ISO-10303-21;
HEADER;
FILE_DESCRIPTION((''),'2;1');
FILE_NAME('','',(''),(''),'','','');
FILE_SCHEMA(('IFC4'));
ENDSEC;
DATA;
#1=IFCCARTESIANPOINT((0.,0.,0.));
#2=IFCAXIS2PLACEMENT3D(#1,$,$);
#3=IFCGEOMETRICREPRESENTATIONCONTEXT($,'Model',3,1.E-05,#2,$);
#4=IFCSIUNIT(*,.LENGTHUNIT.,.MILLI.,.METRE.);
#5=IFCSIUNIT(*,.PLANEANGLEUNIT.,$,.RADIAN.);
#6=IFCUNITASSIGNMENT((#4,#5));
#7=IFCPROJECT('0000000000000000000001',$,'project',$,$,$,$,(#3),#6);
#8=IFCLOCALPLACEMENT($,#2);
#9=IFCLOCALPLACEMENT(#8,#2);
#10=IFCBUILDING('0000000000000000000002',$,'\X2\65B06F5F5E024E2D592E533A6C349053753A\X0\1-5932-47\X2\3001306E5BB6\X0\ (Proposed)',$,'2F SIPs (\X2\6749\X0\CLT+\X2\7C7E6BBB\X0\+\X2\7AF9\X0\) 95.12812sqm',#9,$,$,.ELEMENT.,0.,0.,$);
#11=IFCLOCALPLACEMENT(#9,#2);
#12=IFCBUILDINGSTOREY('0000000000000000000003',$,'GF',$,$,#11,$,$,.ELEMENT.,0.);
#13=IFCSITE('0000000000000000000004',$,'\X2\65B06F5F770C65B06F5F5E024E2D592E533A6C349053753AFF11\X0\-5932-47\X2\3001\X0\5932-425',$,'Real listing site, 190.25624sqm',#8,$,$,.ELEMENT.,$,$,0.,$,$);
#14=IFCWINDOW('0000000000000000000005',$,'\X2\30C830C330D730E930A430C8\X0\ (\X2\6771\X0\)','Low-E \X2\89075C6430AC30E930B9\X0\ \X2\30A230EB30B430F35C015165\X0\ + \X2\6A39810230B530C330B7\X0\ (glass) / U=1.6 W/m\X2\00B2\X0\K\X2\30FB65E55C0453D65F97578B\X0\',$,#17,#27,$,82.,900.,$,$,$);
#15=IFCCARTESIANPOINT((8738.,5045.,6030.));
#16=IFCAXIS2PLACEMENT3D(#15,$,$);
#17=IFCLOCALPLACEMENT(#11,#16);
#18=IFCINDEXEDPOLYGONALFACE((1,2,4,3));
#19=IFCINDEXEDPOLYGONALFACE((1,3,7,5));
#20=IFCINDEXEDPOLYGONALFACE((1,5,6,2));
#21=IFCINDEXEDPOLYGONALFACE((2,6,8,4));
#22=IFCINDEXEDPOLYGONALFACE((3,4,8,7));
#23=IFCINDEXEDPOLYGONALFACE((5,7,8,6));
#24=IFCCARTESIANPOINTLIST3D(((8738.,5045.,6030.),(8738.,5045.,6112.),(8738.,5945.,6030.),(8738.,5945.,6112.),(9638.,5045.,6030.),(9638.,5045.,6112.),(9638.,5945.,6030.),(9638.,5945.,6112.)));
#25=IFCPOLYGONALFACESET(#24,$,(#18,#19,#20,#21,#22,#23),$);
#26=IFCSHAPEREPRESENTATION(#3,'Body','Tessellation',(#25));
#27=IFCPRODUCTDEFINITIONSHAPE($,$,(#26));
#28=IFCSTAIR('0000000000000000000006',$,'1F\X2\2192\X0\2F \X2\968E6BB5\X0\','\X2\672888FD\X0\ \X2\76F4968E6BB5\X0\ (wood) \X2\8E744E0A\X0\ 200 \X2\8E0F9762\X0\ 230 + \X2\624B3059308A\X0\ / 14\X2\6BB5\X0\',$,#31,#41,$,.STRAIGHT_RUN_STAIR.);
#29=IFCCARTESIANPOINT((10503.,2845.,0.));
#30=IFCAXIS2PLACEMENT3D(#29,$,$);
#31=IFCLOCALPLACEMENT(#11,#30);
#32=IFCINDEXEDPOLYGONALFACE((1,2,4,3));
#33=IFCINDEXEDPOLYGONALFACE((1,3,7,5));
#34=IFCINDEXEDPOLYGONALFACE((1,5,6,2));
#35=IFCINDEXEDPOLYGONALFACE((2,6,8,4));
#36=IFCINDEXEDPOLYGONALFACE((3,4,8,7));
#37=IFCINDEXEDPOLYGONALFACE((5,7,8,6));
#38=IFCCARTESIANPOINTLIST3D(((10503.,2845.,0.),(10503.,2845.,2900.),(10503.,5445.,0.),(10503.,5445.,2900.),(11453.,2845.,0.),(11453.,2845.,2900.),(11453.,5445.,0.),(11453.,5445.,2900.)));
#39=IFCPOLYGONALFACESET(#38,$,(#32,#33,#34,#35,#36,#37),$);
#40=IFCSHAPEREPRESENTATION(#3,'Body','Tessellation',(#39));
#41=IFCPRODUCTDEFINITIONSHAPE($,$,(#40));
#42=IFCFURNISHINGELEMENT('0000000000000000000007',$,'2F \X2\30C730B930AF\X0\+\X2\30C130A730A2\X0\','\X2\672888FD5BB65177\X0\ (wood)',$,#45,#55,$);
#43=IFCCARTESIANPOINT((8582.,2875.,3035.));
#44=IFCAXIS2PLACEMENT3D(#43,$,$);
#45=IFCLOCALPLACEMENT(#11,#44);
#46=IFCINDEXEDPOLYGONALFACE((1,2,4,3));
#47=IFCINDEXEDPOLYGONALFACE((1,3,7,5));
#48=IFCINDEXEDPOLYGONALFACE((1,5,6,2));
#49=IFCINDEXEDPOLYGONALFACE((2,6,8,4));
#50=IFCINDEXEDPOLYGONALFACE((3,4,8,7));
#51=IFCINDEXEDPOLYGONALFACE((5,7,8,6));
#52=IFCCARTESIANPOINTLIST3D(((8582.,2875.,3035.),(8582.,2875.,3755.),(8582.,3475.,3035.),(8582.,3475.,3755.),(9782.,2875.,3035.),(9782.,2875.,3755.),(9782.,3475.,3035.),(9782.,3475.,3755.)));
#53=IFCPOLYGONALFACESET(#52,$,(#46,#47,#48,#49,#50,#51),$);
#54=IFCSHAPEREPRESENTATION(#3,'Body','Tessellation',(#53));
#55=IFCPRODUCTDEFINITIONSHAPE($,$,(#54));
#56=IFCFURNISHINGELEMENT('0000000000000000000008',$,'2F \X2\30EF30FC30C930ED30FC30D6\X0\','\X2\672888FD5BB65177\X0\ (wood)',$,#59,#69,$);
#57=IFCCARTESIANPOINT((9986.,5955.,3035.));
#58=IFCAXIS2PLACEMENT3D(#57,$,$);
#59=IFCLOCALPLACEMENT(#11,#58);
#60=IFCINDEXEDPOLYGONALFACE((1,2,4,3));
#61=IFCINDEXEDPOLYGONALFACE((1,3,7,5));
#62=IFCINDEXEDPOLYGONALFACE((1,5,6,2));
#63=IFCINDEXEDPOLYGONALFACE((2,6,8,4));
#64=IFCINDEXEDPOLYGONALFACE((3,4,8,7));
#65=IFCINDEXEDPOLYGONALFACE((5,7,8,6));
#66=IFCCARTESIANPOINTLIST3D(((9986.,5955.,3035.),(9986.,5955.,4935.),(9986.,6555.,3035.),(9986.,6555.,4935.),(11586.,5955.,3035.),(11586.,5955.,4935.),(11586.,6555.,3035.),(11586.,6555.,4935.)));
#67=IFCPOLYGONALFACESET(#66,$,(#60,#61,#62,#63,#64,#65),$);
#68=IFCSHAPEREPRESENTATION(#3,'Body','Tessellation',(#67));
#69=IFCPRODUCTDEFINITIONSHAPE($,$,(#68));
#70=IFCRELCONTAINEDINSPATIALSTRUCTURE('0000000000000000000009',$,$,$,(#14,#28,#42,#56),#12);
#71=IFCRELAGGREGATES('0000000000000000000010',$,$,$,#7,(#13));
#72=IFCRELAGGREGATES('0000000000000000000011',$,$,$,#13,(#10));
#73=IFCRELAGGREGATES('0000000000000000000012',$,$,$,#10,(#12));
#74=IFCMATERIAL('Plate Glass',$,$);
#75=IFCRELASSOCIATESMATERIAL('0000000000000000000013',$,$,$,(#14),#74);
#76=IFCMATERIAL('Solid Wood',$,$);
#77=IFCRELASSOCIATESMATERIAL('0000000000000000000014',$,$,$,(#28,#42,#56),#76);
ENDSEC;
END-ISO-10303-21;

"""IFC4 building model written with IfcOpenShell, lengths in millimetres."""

from ifc_helpers import new_model, si_unit, frame, frame_2d, origin, place, context, project, spatial, rectangle, extrude, material, element, save


model = new_model("IFC4")

# Units and contexts
model_context = context("Model", 3, precision=1e-05, world=origin())
ifc_project = project(units=[si_unit("LENGTHUNIT", "METRE", prefix="MILLI"), si_unit("PLANEANGLEUNIT", "RADIAN")], contexts=[model_context])

# Site, building, storey
site_placement = place(None, origin())
site = spatial("IfcSite", under=ifc_project, at=site_placement, Name="新潟県新潟市中央区水道町１-5932-47、5932-425", ObjectType="Real listing site, 190.25624sqm", CompositionType="ELEMENT", RefElevation=0.0)
building_placement = place(site_placement, origin())
building = spatial("IfcBuilding", under=site, at=building_placement, Name="新潟市中央区水道町1-5932-47、の家 (Proposed)", ObjectType="2F SIPs (杉CLT+籾殻+竹) 95.12812sqm", CompositionType="ELEMENT", ElevationOfRefHeight=0.0, ElevationOfTerrain=0.0)
storey_placement = place(building_placement, origin())
storey = spatial("IfcBuildingStorey", under=building, at=storey_placement, Name="GF", CompositionType="ELEMENT", Elevation=0.0)

# Shared definitions
ifc_material_1 = material(Name="Solid Wood")

# Shared definitions
ifc_material_2 = material(Name="Plate Glass")

# Window
window_1_placement = place(storey_placement, frame((8738.0, 5045.0, 6030.0)))
element("IfcWindow", 1, at=window_1_placement, inside=storey, material=ifc_material_2, Name="トップライト (東)", Description="Low-E 複層ガラス アルゴン封入 + 樹脂サッシ (glass) / U=1.6 W/m²K・日射取得型", OverallHeight=82.0, OverallWidth=900.0, context=model_context, shape_type="SweptSolid", body=[
    extrude(rectangle(XDim=900.0, YDim=900.0, at=frame_2d((450.0, 450.0))), frame((8738.0, 5045.0, 6030.0)), (0.0, 0.0, 1.0), 82.0),
])

# Stair
stair_placement = place(storey_placement, frame((10503.0, 2845.0, 0.0)))
element("IfcStair", 2, at=stair_placement, inside=storey, material=ifc_material_1, Name="1F→2F 階段", Description="木製 直階段 (wood) 蹴上 200 踏面 230 + 手すり / 14段", PredefinedType="STRAIGHT_RUN_STAIR", context=model_context, shape_type="SweptSolid", body=[
    extrude(rectangle(XDim=950.0, YDim=2600.0, at=frame_2d((475.0, 1300.0))), frame((10503.0, 2845.0, 0.0)), (0.0, 0.0, 1.0), 2900.0),
])

# Furnishing elements
furnishing_1_placement = place(storey_placement, frame((8582.0, 2875.0, 3035.0)))
element("IfcFurnishingElement", 3, at=furnishing_1_placement, inside=storey, material=ifc_material_1, Name="2F デスク+チェア", Description="木製家具 (wood)", context=model_context, shape_type="SweptSolid", body=[
    extrude(rectangle(XDim=1200.0, YDim=600.0, at=frame_2d((600.0, 300.0))), frame((8582.0, 2875.0, 3035.0)), (0.0, 0.0, 1.0), 720.0),
])
furnishing_2_placement = place(storey_placement, frame((9986.0, 5955.0, 3035.0)))
element("IfcFurnishingElement", 4, at=furnishing_2_placement, inside=storey, material=ifc_material_1, Name="2F ワードローブ", Description="木製家具 (wood)", context=model_context, shape_type="SweptSolid", body=[
    extrude(rectangle(XDim=1600.0, YDim=600.0, at=frame_2d((800.0, 300.0))), frame((9986.0, 5955.0, 3035.0)), (0.0, 0.0, 1.0), 1900.0),
])

save(model, "model.ifc")
